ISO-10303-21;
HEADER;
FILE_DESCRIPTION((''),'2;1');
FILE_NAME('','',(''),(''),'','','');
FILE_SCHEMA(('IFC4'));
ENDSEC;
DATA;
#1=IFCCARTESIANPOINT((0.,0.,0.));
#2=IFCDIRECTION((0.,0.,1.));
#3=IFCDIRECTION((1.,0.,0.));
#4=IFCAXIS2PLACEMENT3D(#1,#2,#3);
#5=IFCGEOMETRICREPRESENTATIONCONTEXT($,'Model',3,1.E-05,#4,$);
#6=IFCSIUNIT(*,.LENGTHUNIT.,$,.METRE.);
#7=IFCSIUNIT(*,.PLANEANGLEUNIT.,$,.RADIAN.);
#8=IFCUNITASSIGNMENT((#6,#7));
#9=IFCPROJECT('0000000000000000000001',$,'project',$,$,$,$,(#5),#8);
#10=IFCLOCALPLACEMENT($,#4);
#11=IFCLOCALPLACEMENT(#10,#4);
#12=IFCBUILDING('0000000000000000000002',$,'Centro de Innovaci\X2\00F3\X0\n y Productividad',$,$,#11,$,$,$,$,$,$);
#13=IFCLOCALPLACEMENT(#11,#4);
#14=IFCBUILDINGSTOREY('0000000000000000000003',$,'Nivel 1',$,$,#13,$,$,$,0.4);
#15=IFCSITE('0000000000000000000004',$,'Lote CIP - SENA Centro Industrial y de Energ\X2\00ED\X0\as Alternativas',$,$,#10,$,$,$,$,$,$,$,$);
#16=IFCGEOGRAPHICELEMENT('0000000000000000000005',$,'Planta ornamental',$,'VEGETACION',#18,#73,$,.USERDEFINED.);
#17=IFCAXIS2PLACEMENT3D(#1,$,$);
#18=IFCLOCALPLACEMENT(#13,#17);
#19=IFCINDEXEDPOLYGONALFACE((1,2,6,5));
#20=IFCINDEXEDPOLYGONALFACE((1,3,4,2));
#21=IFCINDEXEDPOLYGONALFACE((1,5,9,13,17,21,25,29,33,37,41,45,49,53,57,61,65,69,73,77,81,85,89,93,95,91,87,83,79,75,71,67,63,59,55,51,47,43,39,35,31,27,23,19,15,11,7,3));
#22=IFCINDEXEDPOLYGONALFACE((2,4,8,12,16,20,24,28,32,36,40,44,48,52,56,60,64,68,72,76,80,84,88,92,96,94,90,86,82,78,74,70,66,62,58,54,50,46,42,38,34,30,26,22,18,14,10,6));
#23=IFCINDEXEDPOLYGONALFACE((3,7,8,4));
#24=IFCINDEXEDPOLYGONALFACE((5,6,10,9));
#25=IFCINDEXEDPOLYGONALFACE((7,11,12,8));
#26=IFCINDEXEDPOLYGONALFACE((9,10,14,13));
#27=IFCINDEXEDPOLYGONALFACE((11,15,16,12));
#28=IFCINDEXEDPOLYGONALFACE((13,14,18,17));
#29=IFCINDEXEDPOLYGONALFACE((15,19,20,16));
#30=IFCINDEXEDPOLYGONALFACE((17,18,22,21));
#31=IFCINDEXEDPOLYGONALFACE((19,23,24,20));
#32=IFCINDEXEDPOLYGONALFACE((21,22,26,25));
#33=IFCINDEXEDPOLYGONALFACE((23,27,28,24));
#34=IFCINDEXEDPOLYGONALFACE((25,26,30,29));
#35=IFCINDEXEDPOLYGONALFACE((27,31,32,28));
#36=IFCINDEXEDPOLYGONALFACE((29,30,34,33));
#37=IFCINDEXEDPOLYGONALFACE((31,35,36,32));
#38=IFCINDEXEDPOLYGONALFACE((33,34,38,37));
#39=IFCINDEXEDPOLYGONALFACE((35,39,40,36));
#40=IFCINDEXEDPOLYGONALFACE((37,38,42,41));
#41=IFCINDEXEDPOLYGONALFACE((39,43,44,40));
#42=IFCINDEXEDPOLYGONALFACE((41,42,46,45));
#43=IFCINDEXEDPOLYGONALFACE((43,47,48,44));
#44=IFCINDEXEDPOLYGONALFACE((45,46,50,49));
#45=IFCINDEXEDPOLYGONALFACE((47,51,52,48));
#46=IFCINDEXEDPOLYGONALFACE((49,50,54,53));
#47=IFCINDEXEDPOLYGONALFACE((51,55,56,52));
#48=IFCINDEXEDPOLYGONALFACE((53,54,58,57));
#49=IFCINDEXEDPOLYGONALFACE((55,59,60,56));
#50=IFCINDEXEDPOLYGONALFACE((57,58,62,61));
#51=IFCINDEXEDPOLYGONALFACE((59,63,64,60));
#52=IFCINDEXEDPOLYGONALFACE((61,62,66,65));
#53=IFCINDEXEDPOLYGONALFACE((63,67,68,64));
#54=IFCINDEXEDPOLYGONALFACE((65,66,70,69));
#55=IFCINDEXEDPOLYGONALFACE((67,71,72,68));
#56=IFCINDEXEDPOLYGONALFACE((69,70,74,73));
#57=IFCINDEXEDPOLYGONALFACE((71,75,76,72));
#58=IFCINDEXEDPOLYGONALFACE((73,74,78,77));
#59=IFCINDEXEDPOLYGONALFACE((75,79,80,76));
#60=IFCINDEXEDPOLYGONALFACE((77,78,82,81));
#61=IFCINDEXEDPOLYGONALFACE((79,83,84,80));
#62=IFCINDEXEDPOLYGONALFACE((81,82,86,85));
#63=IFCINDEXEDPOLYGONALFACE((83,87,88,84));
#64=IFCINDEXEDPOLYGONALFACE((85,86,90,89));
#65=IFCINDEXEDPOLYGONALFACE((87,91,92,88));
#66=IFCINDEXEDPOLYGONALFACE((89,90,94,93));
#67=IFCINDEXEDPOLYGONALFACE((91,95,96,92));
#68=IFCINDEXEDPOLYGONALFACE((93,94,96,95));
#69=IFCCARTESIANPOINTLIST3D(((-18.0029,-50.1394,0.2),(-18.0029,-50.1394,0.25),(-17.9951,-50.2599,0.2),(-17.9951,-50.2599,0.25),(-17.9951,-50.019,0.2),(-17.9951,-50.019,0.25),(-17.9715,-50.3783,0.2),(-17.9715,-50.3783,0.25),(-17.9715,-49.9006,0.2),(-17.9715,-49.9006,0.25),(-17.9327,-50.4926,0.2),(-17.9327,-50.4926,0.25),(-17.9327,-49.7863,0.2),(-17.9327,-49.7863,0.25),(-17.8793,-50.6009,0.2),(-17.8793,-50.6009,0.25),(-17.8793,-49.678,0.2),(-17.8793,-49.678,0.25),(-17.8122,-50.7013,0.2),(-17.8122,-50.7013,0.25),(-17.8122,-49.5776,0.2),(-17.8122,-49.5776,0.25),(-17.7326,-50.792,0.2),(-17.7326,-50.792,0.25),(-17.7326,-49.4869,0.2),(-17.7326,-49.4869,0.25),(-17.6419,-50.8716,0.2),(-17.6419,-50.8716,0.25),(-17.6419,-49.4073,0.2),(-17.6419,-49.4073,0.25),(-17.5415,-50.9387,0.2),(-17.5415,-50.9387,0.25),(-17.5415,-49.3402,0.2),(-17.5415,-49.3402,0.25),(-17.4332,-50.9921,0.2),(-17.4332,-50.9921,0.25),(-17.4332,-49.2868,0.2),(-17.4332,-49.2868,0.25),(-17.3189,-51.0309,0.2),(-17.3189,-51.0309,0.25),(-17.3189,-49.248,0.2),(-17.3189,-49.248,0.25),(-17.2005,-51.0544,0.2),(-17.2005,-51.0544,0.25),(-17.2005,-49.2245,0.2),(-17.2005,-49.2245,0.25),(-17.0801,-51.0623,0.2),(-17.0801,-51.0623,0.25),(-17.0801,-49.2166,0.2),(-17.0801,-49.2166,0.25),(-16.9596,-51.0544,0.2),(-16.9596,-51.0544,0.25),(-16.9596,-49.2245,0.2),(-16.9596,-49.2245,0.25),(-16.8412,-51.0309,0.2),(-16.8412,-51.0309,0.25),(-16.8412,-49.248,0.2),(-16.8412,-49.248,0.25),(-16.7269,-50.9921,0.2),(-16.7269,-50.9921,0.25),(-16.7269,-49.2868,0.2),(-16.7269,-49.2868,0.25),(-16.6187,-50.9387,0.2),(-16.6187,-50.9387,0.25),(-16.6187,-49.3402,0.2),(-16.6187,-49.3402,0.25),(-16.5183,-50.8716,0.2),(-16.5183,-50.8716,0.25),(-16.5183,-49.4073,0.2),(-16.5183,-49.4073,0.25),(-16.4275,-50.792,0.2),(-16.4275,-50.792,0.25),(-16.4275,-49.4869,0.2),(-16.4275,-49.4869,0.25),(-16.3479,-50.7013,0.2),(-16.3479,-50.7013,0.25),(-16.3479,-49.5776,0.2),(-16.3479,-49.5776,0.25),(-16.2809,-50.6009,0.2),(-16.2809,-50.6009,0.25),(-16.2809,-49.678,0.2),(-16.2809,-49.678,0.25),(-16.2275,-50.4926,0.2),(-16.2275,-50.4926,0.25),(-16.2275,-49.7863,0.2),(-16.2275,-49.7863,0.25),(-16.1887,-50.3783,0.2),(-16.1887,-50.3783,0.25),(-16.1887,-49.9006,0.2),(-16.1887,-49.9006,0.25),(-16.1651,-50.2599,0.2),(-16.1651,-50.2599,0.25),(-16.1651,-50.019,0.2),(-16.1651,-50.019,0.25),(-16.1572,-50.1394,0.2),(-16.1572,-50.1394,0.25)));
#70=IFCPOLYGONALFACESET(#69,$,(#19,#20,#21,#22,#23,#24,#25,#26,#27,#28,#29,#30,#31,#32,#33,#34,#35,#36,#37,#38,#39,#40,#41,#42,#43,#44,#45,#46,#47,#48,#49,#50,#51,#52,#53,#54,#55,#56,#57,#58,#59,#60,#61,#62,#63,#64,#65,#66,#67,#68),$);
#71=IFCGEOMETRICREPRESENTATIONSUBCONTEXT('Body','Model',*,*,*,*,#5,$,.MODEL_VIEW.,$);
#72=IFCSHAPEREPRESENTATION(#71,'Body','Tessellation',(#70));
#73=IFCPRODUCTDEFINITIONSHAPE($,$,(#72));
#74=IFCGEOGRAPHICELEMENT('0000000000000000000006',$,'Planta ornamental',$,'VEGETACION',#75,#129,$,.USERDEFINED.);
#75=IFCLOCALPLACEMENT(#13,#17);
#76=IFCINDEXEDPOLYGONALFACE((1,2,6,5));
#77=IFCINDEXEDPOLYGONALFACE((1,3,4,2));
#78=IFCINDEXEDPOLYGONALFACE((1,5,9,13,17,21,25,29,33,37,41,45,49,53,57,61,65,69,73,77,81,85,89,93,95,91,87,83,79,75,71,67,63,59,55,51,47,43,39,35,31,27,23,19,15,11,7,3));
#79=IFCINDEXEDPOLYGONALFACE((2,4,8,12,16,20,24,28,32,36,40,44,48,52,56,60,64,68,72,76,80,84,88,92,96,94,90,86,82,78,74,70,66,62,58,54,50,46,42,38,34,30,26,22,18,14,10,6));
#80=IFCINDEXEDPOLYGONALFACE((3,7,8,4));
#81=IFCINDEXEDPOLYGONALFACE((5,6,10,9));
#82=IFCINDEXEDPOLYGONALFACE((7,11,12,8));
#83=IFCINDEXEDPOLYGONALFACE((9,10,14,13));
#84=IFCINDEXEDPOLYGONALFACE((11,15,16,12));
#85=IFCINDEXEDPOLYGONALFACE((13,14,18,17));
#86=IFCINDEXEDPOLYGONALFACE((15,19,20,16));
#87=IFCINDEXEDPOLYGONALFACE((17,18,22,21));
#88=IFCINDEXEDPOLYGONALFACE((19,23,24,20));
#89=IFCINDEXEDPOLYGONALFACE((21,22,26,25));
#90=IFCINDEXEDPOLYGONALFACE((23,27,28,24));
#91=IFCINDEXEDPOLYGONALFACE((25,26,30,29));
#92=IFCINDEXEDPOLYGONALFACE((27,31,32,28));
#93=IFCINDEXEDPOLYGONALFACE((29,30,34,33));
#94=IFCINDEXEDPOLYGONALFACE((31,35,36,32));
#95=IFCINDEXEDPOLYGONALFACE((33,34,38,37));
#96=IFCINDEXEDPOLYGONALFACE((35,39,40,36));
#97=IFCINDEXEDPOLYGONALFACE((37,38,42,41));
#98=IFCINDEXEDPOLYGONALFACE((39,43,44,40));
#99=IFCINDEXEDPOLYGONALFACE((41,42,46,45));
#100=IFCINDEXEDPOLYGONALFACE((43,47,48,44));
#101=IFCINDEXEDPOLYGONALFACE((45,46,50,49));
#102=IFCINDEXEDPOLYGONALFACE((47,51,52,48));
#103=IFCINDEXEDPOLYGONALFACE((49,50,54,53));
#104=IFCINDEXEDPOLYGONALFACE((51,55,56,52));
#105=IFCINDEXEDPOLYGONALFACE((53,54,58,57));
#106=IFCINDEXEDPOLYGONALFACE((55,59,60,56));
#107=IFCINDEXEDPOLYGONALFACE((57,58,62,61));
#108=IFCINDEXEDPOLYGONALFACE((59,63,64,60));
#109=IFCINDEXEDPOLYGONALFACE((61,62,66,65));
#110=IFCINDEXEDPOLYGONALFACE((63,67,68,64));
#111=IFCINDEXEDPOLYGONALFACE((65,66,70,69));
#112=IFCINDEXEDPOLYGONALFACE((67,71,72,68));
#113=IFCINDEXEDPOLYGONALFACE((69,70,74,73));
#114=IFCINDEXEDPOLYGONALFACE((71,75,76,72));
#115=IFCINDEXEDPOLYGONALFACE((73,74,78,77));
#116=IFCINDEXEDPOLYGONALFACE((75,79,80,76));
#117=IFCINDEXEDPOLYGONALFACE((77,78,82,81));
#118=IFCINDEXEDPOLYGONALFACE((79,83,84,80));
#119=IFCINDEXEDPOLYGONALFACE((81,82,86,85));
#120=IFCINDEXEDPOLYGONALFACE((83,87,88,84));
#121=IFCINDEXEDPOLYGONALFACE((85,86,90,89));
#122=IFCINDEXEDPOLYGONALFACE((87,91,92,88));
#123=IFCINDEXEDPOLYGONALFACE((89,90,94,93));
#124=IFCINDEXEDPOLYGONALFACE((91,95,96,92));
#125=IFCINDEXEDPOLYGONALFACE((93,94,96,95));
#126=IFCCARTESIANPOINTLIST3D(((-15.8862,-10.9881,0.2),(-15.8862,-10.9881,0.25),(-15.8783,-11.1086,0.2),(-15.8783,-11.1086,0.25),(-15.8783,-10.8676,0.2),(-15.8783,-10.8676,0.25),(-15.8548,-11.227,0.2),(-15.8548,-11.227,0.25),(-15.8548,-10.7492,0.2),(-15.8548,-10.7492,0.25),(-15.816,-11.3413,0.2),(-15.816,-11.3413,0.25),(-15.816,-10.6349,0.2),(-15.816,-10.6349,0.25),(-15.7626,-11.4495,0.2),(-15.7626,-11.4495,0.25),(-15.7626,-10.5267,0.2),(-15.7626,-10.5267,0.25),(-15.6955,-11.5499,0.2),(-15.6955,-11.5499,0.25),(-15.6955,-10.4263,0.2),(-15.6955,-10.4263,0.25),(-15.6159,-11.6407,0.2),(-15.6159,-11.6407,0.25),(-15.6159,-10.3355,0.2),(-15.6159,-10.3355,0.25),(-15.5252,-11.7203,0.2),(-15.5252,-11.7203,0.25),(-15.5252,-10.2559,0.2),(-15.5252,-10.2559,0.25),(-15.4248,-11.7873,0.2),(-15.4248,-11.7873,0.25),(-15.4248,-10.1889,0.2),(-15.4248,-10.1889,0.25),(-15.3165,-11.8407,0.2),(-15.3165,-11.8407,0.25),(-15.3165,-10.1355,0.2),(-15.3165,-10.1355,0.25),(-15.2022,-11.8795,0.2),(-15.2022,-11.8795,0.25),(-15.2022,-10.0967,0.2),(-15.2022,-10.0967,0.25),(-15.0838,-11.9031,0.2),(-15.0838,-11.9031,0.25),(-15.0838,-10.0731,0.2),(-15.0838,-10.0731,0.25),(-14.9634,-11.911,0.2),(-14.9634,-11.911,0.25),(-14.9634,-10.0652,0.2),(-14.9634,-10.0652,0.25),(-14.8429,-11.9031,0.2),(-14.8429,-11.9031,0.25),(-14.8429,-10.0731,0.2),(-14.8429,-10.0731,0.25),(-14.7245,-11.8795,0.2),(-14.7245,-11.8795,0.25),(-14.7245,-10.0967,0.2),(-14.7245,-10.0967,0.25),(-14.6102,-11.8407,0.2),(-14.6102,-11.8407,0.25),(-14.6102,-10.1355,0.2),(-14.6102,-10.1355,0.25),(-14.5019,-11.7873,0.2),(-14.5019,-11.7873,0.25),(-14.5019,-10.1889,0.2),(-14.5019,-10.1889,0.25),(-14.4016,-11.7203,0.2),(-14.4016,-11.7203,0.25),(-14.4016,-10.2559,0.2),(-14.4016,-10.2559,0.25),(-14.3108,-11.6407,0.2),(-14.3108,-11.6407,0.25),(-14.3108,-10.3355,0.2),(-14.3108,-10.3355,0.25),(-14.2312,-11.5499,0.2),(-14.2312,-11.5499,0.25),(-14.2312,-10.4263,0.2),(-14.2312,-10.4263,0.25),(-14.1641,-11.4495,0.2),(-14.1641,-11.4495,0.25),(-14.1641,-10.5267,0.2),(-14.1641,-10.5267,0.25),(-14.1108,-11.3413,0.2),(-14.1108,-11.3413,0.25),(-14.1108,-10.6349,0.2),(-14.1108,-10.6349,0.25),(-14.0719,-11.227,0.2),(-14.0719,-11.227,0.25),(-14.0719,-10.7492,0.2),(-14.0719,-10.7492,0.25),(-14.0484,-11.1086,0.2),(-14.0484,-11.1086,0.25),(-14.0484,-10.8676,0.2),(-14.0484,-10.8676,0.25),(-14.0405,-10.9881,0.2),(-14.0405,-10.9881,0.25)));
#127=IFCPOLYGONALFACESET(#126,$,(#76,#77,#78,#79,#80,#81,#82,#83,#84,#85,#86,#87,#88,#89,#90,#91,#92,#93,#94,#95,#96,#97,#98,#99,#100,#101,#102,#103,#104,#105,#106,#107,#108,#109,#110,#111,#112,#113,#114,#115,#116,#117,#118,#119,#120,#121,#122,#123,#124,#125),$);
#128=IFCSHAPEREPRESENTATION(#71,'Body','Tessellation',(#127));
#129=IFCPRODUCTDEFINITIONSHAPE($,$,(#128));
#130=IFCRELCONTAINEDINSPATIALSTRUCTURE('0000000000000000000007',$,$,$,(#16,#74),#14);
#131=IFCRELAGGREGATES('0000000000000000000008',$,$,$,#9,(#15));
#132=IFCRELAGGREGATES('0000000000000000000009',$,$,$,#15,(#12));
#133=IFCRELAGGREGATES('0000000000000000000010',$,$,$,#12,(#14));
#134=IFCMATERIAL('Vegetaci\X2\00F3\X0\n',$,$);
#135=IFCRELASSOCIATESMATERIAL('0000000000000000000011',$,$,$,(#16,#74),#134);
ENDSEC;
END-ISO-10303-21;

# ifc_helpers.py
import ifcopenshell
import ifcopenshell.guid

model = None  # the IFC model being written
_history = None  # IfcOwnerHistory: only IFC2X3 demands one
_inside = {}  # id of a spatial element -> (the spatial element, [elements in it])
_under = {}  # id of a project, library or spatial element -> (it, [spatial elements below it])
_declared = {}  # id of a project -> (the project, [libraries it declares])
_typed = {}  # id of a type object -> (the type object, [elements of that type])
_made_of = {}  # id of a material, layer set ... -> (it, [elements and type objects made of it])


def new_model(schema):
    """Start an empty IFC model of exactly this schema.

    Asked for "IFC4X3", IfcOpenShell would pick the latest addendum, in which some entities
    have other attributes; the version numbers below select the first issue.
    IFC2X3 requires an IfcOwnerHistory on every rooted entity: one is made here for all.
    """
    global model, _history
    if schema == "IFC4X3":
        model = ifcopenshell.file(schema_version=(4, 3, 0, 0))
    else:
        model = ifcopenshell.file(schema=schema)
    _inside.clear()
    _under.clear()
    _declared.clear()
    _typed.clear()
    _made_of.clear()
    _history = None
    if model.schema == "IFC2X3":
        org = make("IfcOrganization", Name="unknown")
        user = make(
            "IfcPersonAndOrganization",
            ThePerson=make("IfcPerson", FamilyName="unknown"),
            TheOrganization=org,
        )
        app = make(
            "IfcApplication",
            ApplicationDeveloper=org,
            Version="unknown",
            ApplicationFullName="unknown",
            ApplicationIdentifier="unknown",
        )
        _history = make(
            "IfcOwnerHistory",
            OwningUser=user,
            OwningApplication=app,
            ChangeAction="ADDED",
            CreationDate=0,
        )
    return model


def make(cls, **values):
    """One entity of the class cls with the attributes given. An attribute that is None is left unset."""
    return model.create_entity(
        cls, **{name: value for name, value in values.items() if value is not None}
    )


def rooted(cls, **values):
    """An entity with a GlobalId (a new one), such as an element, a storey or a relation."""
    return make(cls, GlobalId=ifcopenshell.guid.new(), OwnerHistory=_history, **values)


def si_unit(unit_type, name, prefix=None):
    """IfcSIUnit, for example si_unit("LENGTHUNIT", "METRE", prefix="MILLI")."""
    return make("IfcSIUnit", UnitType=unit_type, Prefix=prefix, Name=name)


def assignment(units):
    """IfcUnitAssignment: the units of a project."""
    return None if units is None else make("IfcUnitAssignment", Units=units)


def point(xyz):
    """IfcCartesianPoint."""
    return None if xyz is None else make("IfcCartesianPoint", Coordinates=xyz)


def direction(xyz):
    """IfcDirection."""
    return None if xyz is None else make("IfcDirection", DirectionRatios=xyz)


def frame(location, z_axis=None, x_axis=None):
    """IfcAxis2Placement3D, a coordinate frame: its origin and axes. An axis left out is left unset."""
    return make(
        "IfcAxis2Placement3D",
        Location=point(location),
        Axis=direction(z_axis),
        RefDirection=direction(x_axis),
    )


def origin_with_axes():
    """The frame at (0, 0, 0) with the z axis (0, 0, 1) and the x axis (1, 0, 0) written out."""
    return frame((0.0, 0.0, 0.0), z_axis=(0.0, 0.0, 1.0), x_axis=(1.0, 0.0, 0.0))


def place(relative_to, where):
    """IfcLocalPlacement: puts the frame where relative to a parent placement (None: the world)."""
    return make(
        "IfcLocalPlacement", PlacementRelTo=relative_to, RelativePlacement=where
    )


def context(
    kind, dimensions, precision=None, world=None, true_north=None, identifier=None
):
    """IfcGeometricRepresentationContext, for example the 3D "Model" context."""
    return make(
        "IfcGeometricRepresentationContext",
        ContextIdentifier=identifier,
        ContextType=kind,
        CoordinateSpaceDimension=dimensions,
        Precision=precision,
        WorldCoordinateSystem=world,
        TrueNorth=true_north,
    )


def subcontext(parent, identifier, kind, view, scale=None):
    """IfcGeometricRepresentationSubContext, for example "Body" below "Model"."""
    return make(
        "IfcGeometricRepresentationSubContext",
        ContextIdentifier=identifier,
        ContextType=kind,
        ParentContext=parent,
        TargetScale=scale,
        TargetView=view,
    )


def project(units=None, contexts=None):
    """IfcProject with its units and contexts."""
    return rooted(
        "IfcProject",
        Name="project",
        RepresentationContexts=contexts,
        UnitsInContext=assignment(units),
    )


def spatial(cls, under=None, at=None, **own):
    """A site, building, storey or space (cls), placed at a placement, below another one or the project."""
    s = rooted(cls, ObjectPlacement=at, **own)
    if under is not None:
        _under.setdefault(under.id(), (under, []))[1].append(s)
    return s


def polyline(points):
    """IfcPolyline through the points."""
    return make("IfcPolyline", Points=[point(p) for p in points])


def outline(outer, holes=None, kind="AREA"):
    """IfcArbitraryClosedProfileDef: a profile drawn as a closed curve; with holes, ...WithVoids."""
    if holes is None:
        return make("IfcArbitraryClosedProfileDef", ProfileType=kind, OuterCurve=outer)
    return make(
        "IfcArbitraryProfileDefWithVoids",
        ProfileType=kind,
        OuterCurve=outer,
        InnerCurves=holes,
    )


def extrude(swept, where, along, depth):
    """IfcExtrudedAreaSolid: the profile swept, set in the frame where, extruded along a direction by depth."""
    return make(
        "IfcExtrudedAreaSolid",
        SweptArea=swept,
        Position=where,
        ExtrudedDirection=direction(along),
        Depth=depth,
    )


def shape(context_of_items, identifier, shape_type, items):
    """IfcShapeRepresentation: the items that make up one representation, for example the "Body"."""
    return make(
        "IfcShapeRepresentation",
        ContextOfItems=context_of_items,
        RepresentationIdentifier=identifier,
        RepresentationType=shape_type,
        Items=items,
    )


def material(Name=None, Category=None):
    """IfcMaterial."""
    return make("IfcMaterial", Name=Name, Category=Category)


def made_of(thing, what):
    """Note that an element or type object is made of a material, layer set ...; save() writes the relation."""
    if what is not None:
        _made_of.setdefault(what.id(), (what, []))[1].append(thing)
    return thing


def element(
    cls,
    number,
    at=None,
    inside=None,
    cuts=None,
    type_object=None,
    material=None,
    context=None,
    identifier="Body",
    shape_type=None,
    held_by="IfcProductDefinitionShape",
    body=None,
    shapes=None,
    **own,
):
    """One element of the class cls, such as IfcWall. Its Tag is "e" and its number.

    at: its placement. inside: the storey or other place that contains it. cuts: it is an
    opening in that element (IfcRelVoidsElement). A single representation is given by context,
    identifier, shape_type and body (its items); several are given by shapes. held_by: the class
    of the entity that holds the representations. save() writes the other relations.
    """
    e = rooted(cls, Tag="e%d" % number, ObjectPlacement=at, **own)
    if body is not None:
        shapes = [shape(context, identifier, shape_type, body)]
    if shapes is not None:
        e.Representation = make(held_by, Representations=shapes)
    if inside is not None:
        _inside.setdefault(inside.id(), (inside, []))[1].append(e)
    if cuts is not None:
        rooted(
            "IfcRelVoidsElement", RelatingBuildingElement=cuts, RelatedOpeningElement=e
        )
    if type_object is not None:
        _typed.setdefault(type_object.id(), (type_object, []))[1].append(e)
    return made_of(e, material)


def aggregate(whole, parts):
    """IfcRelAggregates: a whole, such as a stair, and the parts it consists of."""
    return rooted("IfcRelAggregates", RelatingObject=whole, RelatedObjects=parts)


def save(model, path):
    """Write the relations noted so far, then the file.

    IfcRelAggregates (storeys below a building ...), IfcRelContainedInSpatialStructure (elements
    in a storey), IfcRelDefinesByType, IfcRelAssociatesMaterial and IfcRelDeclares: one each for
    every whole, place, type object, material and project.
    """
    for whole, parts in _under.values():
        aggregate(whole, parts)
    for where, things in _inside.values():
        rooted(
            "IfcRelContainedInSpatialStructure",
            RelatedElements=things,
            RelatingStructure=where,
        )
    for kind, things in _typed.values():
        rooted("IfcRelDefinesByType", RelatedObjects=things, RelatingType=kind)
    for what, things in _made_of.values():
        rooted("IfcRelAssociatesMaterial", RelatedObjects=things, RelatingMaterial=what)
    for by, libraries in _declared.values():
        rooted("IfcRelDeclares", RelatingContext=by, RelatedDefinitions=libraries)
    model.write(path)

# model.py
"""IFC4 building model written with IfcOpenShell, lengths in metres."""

from ifc_helpers import new_model, si_unit, frame, origin_with_axes, place, context, subcontext, project, spatial, polyline, outline, extrude, material, element, save


model = new_model("IFC4")

# Units and contexts
model_context = context("Model", 3, precision=1e-05, world=origin_with_axes())
body_context = subcontext(model_context, "Body", "Model", "MODEL_VIEW")
ifc_project = project(units=[si_unit("LENGTHUNIT", "METRE"), si_unit("PLANEANGLEUNIT", "RADIAN")], contexts=[model_context])

# Site, building, storey
site_placement = place(None, origin_with_axes())
site = spatial("IfcSite", under=ifc_project, at=site_placement, Name="Lote CIP - SENA Centro Industrial y de Energías Alternativas")
building_placement = place(site_placement, origin_with_axes())
building = spatial("IfcBuilding", under=site, at=building_placement, Name="Centro de Innovación y Productividad")
storey_placement = place(building_placement, origin_with_axes())
storey = spatial("IfcBuildingStorey", under=building, at=storey_placement, Name="Nivel 1", Elevation=0.4)

# Geographic elements
ifc_material = material(Name="Vegetación")
geographic_element_1_placement = place(storey_placement, origin_with_axes())
element("IfcGeographicElement", 1, at=geographic_element_1_placement, inside=storey, material=ifc_material, Name="Planta ornamental", ObjectType="VEGETACION", PredefinedType="USERDEFINED", context=body_context, shape_type="SweptSolid", body=[
    extrude(outline(polyline([(-16.1572, -50.1394), (-16.1651, -50.2599), (-16.1887, -50.3783), (-16.2275, -50.4926), (-16.2809, -50.6009), (-16.3479, -50.7013), (-16.4275, -50.792), (-16.5183, -50.8716), (-16.6187, -50.9387), (-16.7269, -50.9921), (-16.8412, -51.0309), (-16.9596, -51.0544), (-17.0801, -51.0623), (-17.2005, -51.0544), (-17.3189, -51.0309), (-17.4332, -50.9921), (-17.5415, -50.9387), (-17.6419, -50.8716), (-17.7326, -50.792), (-17.8122, -50.7013), (-17.8793, -50.6009), (-17.9327, -50.4926), (-17.9715, -50.3783), (-17.9951, -50.2599), (-18.0029, -50.1394), (-17.9951, -50.019), (-17.9715, -49.9006), (-17.9327, -49.7863), (-17.8793, -49.678), (-17.8122, -49.5776), (-17.7326, -49.4869), (-17.6419, -49.4073), (-17.5415, -49.3402), (-17.4332, -49.2868), (-17.3189, -49.248), (-17.2005, -49.2245), (-17.0801, -49.2166), (-16.9596, -49.2245), (-16.8412, -49.248), (-16.7269, -49.2868), (-16.6187, -49.3402), (-16.5183, -49.4073), (-16.4275, -49.4869), (-16.3479, -49.5776), (-16.2809, -49.678), (-16.2275, -49.7863), (-16.1887, -49.9006), (-16.1651, -50.019), (-16.1572, -50.1394)])), frame((0.0, 0.0, 0.2)), (0.0, 0.0, 1.0), 0.05),
])
geographic_element_2_placement = place(storey_placement, origin_with_axes())
element("IfcGeographicElement", 2, at=geographic_element_2_placement, inside=storey, material=ifc_material, Name="Planta ornamental", ObjectType="VEGETACION", PredefinedType="USERDEFINED", context=body_context, shape_type="SweptSolid", body=[
    extrude(outline(polyline([(-14.0405, -10.9881), (-14.0484, -11.1086), (-14.0719, -11.227), (-14.1108, -11.3413), (-14.1641, -11.4495), (-14.2312, -11.5499), (-14.3108, -11.6407), (-14.4016, -11.7203), (-14.5019, -11.7873), (-14.6102, -11.8407), (-14.7245, -11.8795), (-14.8429, -11.9031), (-14.9634, -11.911), (-15.0838, -11.9031), (-15.2022, -11.8795), (-15.3165, -11.8407), (-15.4248, -11.7873), (-15.5252, -11.7203), (-15.6159, -11.6407), (-15.6955, -11.5499), (-15.7626, -11.4495), (-15.816, -11.3413), (-15.8548, -11.227), (-15.8783, -11.1086), (-15.8862, -10.9881), (-15.8783, -10.8676), (-15.8548, -10.7492), (-15.816, -10.6349), (-15.7626, -10.5267), (-15.6955, -10.4263), (-15.6159, -10.3355), (-15.5252, -10.2559), (-15.4248, -10.1889), (-15.3165, -10.1355), (-15.2022, -10.0967), (-15.0838, -10.0731), (-14.9634, -10.0652), (-14.8429, -10.0731), (-14.7245, -10.0967), (-14.6102, -10.1355), (-14.5019, -10.1889), (-14.4016, -10.2559), (-14.3108, -10.3355), (-14.2312, -10.4263), (-14.1641, -10.5267), (-14.1108, -10.6349), (-14.0719, -10.7492), (-14.0484, -10.8676), (-14.0405, -10.9881)])), frame((0.0, 0.0, 0.2)), (0.0, 0.0, 1.0), 0.05),
])

save(model, "model.ifc")
